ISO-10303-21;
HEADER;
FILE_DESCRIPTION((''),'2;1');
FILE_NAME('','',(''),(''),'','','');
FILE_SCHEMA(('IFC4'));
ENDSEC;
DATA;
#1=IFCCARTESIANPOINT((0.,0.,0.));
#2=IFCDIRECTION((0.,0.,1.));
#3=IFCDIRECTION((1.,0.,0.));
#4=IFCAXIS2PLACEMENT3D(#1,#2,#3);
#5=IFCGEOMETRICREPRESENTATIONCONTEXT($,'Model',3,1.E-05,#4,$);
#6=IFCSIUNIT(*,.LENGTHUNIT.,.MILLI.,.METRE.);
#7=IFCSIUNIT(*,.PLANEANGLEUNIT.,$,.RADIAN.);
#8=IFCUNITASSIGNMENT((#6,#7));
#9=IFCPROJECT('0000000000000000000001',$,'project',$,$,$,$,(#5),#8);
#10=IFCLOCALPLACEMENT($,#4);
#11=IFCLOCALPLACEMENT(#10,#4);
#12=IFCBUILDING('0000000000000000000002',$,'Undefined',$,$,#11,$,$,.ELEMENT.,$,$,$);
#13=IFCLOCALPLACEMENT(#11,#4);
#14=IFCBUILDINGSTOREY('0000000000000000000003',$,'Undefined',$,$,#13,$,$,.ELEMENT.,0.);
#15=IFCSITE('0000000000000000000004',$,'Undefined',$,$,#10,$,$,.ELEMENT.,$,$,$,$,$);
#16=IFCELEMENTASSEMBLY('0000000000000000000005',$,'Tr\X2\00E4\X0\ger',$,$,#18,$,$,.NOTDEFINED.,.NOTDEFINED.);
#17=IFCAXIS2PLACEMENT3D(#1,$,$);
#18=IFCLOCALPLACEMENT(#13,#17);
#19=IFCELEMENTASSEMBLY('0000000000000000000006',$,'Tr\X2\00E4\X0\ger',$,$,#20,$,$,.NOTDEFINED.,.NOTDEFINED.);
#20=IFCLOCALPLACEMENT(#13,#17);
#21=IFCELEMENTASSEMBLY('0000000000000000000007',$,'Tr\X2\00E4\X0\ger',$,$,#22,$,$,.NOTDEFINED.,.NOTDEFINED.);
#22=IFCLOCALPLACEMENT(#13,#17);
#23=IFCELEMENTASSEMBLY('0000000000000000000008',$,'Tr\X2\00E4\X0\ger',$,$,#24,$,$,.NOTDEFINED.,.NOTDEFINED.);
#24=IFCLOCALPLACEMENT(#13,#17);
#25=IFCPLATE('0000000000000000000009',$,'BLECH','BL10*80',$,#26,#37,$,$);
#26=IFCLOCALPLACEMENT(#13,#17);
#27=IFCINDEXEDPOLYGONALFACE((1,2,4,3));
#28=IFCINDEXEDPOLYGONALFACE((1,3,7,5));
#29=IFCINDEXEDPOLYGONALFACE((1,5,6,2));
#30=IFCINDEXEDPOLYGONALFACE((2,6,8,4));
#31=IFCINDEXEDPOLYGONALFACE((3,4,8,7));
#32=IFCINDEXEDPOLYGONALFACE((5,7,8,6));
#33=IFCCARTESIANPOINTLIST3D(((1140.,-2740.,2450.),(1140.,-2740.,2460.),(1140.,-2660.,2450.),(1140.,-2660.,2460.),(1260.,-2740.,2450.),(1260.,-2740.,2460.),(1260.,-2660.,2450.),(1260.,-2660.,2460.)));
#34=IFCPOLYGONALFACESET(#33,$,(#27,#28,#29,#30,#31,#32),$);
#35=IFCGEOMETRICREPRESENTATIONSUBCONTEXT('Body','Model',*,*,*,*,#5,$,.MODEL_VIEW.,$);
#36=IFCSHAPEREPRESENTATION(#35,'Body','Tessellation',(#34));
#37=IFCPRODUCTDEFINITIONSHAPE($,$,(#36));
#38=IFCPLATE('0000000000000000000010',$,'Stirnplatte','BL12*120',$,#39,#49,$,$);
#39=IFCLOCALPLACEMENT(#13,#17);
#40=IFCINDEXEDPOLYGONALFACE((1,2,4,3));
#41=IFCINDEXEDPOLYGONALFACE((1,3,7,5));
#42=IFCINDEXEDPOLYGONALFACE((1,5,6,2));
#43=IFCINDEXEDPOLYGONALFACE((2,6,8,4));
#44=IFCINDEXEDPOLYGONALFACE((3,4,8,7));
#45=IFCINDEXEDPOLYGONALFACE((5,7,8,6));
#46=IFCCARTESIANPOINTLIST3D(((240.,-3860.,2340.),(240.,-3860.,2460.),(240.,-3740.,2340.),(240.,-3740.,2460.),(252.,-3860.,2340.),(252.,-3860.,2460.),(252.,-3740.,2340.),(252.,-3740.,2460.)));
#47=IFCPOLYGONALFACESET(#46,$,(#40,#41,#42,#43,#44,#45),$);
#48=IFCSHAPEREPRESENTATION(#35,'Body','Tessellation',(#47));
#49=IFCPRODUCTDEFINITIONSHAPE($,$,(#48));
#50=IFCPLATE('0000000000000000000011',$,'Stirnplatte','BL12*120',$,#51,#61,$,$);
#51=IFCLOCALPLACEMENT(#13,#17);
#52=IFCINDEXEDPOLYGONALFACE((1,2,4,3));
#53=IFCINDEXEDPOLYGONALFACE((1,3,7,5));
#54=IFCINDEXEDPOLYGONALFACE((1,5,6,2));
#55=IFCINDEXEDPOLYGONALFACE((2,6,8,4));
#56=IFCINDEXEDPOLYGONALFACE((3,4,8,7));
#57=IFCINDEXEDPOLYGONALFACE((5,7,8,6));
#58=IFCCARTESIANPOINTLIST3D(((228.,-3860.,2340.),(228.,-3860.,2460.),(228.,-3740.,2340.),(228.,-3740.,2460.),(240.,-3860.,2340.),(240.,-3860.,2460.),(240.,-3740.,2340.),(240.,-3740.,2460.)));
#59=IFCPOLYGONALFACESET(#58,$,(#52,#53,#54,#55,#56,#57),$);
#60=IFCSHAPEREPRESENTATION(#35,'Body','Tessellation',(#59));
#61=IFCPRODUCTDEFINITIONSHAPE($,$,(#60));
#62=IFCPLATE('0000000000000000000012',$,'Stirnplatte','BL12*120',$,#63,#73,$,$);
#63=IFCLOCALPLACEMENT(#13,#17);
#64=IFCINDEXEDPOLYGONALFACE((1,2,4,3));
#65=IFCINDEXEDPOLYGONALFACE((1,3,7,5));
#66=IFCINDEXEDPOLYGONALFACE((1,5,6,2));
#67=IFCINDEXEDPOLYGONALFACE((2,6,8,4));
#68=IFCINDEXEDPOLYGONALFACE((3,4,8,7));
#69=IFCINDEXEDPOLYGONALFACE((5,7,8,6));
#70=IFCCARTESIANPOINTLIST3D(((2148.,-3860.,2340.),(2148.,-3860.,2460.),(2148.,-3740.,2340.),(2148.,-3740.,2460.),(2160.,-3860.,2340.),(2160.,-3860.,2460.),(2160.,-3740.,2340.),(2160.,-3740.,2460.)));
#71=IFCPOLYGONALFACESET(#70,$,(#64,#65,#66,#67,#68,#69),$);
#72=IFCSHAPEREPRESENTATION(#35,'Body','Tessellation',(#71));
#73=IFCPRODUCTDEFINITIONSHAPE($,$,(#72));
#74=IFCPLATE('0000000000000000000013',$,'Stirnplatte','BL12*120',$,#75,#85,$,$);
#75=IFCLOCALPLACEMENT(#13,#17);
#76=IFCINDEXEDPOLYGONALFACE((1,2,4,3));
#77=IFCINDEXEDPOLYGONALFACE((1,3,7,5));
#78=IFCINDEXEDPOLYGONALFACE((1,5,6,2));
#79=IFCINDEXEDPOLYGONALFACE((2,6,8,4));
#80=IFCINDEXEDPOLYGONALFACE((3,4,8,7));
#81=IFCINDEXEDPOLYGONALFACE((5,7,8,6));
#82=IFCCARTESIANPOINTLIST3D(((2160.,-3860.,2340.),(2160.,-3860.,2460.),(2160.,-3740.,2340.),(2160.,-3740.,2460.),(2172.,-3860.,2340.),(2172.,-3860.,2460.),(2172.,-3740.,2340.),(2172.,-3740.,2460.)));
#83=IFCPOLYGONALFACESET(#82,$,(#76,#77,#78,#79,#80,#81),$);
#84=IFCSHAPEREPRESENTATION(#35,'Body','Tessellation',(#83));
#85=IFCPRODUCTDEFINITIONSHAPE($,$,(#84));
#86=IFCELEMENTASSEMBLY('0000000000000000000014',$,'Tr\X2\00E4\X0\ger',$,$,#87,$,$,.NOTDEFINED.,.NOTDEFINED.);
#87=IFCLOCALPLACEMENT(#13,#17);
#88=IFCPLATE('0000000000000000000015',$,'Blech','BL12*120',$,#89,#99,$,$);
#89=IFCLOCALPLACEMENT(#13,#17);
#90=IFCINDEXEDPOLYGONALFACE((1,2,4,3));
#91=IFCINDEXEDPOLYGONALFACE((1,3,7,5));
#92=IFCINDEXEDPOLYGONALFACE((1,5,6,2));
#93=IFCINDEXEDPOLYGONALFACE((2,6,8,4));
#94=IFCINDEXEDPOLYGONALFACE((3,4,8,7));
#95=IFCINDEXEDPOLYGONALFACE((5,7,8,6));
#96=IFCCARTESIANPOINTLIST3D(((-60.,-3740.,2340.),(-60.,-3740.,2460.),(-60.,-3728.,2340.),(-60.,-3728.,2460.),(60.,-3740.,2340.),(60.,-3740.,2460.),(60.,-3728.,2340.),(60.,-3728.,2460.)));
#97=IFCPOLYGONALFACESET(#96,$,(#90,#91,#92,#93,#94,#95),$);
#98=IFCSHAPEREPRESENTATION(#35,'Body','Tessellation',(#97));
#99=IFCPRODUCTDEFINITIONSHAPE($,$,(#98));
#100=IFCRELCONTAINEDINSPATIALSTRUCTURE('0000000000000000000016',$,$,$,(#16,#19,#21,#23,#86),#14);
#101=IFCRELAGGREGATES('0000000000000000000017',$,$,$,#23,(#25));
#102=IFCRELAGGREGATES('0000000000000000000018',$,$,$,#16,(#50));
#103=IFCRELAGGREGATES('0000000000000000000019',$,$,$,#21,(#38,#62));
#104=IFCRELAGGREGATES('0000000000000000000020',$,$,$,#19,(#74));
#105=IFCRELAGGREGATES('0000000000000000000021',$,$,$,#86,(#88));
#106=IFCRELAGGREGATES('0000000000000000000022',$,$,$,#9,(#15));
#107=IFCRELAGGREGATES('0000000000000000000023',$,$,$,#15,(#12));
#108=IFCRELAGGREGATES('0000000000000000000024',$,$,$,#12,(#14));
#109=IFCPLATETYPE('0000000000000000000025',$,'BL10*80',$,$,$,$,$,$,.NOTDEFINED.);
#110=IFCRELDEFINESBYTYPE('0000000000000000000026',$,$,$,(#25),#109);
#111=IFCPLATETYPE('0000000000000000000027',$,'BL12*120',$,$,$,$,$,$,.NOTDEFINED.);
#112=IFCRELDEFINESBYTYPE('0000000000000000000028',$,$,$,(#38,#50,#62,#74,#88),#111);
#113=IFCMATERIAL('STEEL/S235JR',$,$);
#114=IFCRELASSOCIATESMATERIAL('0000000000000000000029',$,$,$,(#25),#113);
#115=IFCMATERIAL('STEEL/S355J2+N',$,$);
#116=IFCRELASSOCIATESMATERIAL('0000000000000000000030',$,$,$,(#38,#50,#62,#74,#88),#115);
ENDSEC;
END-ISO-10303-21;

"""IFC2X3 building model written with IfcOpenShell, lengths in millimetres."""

from ifc_helpers import new_model, si_unit, frame, origin_with_axes, place, context, subcontext, project, spatial, polyline, outline, extrude, material, type_object, element, aggregate, save


model = new_model("IFC2X3")

# Units and contexts
model_context = context("Model", 3, precision=1e-05, world=origin_with_axes())
body_context = subcontext(model_context, "Body", "Model", "MODEL_VIEW")
ifc_project = project(units=[si_unit("LENGTHUNIT", "METRE", prefix="MILLI"), si_unit("PLANEANGLEUNIT", "RADIAN")], contexts=[model_context])

# Site, building, storey
site_placement = place(None, origin_with_axes())
site = spatial("IfcSite", under=ifc_project, at=site_placement, Name="Undefined", CompositionType="ELEMENT")
building_placement = place(site_placement, origin_with_axes())
building = spatial("IfcBuilding", under=site, at=building_placement, Name="Undefined", CompositionType="ELEMENT")
storey_placement = place(building_placement, origin_with_axes())
storey = spatial("IfcBuildingStorey", under=building, at=storey_placement, Name="Undefined", CompositionType="ELEMENT", Elevation=0.0)

# Shared definitions
ifc_material_1 = material(Name="STEEL/S235JR")

# Element assemblies
assembly_1_placement = place(storey_placement, origin_with_axes())
assembly_1 = element("IfcElementAssembly", 1, at=assembly_1_placement, inside=storey, Name="Träger", AssemblyPlace="NOTDEFINED", PredefinedType="NOTDEFINED")
assembly_2_placement = place(storey_placement, origin_with_axes())
assembly_2 = element("IfcElementAssembly", 2, at=assembly_2_placement, inside=storey, Name="Träger", AssemblyPlace="NOTDEFINED", PredefinedType="NOTDEFINED")

# Element assembly
assembly_3_placement = place(storey_placement, origin_with_axes())
assembly_3 = element("IfcElementAssembly", 3, at=assembly_3_placement, inside=storey, Name="Träger", AssemblyPlace="NOTDEFINED", PredefinedType="NOTDEFINED")

# Shared definitions
plate_type_1 = type_object("IfcPlateType", Name="BL10*80", PredefinedType="NOTDEFINED")

# Element assembly, plate
assembly_4_placement = place(storey_placement, origin_with_axes())
assembly_4 = element("IfcElementAssembly", 4, at=assembly_4_placement, inside=storey, Name="Träger", AssemblyPlace="NOTDEFINED", PredefinedType="NOTDEFINED")
plate_1_placement = place(assembly_4_placement, frame((1140.0, -2740.0, 2455.0), z_axis=(0.0, 0.0, 1.0), x_axis=(1.0, 0.0, 0.0)))
plate_1 = element("IfcPlate", 5, at=plate_1_placement, type_object=plate_type_1, material=ifc_material_1, Name="BLECH", Description="BL10*80", context=body_context, shape_type="SweptSolid", body=[
    extrude(outline(polyline([(0.0, 0.0), (120.0, 0.0), (120.0, 80.0), (0.0, 80.0), (0.0, 0.0)])), frame((0.0, 0.0, -5.0), z_axis=(0.0, 0.0, 1.0), x_axis=(1.0, 0.0, 0.0)), (0.0, 0.0, 1.0), 10.0),
])
aggregate(assembly_4, [plate_1])

# Plates
ifc_material_2 = material(Name="STEEL/S355J2+N")
plate_type_2 = type_object("IfcPlateType", Name="BL12*120", PredefinedType="NOTDEFINED")
plate_2_placement = place(assembly_3_placement, frame((246.0, -3800.0, 2340.0), z_axis=(1.0, 0.0, 0.0), x_axis=(0.0, 0.0, 1.0)))
plate_2 = element("IfcPlate", 6, at=plate_2_placement, type_object=plate_type_2, material=ifc_material_2, Name="Stirnplatte", Description="BL12*120", context=body_context, shape_type="SweptSolid", body=[
    extrude(outline(polyline([(0.0, -60.0), (0.0, 60.0), (120.0, 60.0), (120.0, -60.0), (0.0, -60.0)])), frame((0.0, 0.0, -6.0), z_axis=(0.0, 0.0, 1.0), x_axis=(1.0, 0.0, 0.0)), (0.0, 0.0, 1.0), 12.0),
])
plate_3_placement = place(assembly_1_placement, frame((234.0, -3800.0, 2340.0), z_axis=(1.0, 0.0, 0.0), x_axis=(0.0, 0.0, 1.0)))
plate_3 = element("IfcPlate", 7, at=plate_3_placement, type_object=plate_type_2, material=ifc_material_2, Name="Stirnplatte", Description="BL12*120", context=body_context, shape_type="SweptSolid", body=[
    extrude(outline(polyline([(0.0, -60.0), (0.0, 60.0), (120.0, 60.0), (120.0, -60.0), (0.0, -60.0)])), frame((0.0, 0.0, -6.0), z_axis=(0.0, 0.0, 1.0), x_axis=(1.0, 0.0, 0.0)), (0.0, 0.0, 1.0), 12.0),
])
aggregate(assembly_1, [plate_3])
plate_4_placement = place(assembly_3_placement, frame((2154.0, -3800.0, 2340.0), z_axis=(-1.0, 0.0, 0.0), x_axis=(0.0, 0.0, 1.0)))
plate_4 = element("IfcPlate", 8, at=plate_4_placement, type_object=plate_type_2, material=ifc_material_2, Name="Stirnplatte", Description="BL12*120", context=body_context, shape_type="SweptSolid", body=[
    extrude(outline(polyline([(0.0, -60.0), (0.0, 60.0), (120.0, 60.0), (120.0, -60.0), (0.0, -60.0)])), frame((0.0, 0.0, -6.0), z_axis=(0.0, 0.0, 1.0), x_axis=(1.0, 0.0, 0.0)), (0.0, 0.0, 1.0), 12.0),
])
aggregate(assembly_3, [plate_2, plate_4])
plate_5_placement = place(assembly_2_placement, frame((2166.0, -3800.0, 2340.0), z_axis=(-1.0, 0.0, 0.0), x_axis=(0.0, 0.0, 1.0)))
plate_5 = element("IfcPlate", 9, at=plate_5_placement, type_object=plate_type_2, material=ifc_material_2, Name="Stirnplatte", Description="BL12*120", context=body_context, shape_type="SweptSolid", body=[
    extrude(outline(polyline([(0.0, -60.0), (0.0, 60.0), (120.0, 60.0), (120.0, -60.0), (0.0, -60.0)])), frame((0.0, 0.0, -6.0), z_axis=(0.0, 0.0, 1.0), x_axis=(1.0, 0.0, 0.0)), (0.0, 0.0, 1.0), 12.0),
])
aggregate(assembly_2, [plate_5])

# Element assembly, plate
assembly_5_placement = place(storey_placement, origin_with_axes())
assembly_5 = element("IfcElementAssembly", 10, at=assembly_5_placement, inside=storey, Name="Träger", AssemblyPlace="NOTDEFINED", PredefinedType="NOTDEFINED")
plate_6_placement = place(assembly_5_placement, frame((0.0, -3734.0, 2340.0), z_axis=(0.0, 1.0, 0.0), x_axis=(0.0, 0.0, 1.0)))
plate_6 = element("IfcPlate", 11, at=plate_6_placement, type_object=plate_type_2, material=ifc_material_2, Name="Blech", Description="BL12*120", context=body_context, shape_type="SweptSolid", body=[
    extrude(outline(polyline([(0.0, -60.0), (0.0, 60.0), (120.0, 60.0), (120.0, -60.0), (0.0, -60.0)])), frame((0.0, 0.0, -6.0), z_axis=(0.0, 0.0, 1.0), x_axis=(1.0, 0.0, 0.0)), (0.0, 0.0, 1.0), 12.0),
])
aggregate(assembly_5, [plate_6])

save(model, "model.ifc")
